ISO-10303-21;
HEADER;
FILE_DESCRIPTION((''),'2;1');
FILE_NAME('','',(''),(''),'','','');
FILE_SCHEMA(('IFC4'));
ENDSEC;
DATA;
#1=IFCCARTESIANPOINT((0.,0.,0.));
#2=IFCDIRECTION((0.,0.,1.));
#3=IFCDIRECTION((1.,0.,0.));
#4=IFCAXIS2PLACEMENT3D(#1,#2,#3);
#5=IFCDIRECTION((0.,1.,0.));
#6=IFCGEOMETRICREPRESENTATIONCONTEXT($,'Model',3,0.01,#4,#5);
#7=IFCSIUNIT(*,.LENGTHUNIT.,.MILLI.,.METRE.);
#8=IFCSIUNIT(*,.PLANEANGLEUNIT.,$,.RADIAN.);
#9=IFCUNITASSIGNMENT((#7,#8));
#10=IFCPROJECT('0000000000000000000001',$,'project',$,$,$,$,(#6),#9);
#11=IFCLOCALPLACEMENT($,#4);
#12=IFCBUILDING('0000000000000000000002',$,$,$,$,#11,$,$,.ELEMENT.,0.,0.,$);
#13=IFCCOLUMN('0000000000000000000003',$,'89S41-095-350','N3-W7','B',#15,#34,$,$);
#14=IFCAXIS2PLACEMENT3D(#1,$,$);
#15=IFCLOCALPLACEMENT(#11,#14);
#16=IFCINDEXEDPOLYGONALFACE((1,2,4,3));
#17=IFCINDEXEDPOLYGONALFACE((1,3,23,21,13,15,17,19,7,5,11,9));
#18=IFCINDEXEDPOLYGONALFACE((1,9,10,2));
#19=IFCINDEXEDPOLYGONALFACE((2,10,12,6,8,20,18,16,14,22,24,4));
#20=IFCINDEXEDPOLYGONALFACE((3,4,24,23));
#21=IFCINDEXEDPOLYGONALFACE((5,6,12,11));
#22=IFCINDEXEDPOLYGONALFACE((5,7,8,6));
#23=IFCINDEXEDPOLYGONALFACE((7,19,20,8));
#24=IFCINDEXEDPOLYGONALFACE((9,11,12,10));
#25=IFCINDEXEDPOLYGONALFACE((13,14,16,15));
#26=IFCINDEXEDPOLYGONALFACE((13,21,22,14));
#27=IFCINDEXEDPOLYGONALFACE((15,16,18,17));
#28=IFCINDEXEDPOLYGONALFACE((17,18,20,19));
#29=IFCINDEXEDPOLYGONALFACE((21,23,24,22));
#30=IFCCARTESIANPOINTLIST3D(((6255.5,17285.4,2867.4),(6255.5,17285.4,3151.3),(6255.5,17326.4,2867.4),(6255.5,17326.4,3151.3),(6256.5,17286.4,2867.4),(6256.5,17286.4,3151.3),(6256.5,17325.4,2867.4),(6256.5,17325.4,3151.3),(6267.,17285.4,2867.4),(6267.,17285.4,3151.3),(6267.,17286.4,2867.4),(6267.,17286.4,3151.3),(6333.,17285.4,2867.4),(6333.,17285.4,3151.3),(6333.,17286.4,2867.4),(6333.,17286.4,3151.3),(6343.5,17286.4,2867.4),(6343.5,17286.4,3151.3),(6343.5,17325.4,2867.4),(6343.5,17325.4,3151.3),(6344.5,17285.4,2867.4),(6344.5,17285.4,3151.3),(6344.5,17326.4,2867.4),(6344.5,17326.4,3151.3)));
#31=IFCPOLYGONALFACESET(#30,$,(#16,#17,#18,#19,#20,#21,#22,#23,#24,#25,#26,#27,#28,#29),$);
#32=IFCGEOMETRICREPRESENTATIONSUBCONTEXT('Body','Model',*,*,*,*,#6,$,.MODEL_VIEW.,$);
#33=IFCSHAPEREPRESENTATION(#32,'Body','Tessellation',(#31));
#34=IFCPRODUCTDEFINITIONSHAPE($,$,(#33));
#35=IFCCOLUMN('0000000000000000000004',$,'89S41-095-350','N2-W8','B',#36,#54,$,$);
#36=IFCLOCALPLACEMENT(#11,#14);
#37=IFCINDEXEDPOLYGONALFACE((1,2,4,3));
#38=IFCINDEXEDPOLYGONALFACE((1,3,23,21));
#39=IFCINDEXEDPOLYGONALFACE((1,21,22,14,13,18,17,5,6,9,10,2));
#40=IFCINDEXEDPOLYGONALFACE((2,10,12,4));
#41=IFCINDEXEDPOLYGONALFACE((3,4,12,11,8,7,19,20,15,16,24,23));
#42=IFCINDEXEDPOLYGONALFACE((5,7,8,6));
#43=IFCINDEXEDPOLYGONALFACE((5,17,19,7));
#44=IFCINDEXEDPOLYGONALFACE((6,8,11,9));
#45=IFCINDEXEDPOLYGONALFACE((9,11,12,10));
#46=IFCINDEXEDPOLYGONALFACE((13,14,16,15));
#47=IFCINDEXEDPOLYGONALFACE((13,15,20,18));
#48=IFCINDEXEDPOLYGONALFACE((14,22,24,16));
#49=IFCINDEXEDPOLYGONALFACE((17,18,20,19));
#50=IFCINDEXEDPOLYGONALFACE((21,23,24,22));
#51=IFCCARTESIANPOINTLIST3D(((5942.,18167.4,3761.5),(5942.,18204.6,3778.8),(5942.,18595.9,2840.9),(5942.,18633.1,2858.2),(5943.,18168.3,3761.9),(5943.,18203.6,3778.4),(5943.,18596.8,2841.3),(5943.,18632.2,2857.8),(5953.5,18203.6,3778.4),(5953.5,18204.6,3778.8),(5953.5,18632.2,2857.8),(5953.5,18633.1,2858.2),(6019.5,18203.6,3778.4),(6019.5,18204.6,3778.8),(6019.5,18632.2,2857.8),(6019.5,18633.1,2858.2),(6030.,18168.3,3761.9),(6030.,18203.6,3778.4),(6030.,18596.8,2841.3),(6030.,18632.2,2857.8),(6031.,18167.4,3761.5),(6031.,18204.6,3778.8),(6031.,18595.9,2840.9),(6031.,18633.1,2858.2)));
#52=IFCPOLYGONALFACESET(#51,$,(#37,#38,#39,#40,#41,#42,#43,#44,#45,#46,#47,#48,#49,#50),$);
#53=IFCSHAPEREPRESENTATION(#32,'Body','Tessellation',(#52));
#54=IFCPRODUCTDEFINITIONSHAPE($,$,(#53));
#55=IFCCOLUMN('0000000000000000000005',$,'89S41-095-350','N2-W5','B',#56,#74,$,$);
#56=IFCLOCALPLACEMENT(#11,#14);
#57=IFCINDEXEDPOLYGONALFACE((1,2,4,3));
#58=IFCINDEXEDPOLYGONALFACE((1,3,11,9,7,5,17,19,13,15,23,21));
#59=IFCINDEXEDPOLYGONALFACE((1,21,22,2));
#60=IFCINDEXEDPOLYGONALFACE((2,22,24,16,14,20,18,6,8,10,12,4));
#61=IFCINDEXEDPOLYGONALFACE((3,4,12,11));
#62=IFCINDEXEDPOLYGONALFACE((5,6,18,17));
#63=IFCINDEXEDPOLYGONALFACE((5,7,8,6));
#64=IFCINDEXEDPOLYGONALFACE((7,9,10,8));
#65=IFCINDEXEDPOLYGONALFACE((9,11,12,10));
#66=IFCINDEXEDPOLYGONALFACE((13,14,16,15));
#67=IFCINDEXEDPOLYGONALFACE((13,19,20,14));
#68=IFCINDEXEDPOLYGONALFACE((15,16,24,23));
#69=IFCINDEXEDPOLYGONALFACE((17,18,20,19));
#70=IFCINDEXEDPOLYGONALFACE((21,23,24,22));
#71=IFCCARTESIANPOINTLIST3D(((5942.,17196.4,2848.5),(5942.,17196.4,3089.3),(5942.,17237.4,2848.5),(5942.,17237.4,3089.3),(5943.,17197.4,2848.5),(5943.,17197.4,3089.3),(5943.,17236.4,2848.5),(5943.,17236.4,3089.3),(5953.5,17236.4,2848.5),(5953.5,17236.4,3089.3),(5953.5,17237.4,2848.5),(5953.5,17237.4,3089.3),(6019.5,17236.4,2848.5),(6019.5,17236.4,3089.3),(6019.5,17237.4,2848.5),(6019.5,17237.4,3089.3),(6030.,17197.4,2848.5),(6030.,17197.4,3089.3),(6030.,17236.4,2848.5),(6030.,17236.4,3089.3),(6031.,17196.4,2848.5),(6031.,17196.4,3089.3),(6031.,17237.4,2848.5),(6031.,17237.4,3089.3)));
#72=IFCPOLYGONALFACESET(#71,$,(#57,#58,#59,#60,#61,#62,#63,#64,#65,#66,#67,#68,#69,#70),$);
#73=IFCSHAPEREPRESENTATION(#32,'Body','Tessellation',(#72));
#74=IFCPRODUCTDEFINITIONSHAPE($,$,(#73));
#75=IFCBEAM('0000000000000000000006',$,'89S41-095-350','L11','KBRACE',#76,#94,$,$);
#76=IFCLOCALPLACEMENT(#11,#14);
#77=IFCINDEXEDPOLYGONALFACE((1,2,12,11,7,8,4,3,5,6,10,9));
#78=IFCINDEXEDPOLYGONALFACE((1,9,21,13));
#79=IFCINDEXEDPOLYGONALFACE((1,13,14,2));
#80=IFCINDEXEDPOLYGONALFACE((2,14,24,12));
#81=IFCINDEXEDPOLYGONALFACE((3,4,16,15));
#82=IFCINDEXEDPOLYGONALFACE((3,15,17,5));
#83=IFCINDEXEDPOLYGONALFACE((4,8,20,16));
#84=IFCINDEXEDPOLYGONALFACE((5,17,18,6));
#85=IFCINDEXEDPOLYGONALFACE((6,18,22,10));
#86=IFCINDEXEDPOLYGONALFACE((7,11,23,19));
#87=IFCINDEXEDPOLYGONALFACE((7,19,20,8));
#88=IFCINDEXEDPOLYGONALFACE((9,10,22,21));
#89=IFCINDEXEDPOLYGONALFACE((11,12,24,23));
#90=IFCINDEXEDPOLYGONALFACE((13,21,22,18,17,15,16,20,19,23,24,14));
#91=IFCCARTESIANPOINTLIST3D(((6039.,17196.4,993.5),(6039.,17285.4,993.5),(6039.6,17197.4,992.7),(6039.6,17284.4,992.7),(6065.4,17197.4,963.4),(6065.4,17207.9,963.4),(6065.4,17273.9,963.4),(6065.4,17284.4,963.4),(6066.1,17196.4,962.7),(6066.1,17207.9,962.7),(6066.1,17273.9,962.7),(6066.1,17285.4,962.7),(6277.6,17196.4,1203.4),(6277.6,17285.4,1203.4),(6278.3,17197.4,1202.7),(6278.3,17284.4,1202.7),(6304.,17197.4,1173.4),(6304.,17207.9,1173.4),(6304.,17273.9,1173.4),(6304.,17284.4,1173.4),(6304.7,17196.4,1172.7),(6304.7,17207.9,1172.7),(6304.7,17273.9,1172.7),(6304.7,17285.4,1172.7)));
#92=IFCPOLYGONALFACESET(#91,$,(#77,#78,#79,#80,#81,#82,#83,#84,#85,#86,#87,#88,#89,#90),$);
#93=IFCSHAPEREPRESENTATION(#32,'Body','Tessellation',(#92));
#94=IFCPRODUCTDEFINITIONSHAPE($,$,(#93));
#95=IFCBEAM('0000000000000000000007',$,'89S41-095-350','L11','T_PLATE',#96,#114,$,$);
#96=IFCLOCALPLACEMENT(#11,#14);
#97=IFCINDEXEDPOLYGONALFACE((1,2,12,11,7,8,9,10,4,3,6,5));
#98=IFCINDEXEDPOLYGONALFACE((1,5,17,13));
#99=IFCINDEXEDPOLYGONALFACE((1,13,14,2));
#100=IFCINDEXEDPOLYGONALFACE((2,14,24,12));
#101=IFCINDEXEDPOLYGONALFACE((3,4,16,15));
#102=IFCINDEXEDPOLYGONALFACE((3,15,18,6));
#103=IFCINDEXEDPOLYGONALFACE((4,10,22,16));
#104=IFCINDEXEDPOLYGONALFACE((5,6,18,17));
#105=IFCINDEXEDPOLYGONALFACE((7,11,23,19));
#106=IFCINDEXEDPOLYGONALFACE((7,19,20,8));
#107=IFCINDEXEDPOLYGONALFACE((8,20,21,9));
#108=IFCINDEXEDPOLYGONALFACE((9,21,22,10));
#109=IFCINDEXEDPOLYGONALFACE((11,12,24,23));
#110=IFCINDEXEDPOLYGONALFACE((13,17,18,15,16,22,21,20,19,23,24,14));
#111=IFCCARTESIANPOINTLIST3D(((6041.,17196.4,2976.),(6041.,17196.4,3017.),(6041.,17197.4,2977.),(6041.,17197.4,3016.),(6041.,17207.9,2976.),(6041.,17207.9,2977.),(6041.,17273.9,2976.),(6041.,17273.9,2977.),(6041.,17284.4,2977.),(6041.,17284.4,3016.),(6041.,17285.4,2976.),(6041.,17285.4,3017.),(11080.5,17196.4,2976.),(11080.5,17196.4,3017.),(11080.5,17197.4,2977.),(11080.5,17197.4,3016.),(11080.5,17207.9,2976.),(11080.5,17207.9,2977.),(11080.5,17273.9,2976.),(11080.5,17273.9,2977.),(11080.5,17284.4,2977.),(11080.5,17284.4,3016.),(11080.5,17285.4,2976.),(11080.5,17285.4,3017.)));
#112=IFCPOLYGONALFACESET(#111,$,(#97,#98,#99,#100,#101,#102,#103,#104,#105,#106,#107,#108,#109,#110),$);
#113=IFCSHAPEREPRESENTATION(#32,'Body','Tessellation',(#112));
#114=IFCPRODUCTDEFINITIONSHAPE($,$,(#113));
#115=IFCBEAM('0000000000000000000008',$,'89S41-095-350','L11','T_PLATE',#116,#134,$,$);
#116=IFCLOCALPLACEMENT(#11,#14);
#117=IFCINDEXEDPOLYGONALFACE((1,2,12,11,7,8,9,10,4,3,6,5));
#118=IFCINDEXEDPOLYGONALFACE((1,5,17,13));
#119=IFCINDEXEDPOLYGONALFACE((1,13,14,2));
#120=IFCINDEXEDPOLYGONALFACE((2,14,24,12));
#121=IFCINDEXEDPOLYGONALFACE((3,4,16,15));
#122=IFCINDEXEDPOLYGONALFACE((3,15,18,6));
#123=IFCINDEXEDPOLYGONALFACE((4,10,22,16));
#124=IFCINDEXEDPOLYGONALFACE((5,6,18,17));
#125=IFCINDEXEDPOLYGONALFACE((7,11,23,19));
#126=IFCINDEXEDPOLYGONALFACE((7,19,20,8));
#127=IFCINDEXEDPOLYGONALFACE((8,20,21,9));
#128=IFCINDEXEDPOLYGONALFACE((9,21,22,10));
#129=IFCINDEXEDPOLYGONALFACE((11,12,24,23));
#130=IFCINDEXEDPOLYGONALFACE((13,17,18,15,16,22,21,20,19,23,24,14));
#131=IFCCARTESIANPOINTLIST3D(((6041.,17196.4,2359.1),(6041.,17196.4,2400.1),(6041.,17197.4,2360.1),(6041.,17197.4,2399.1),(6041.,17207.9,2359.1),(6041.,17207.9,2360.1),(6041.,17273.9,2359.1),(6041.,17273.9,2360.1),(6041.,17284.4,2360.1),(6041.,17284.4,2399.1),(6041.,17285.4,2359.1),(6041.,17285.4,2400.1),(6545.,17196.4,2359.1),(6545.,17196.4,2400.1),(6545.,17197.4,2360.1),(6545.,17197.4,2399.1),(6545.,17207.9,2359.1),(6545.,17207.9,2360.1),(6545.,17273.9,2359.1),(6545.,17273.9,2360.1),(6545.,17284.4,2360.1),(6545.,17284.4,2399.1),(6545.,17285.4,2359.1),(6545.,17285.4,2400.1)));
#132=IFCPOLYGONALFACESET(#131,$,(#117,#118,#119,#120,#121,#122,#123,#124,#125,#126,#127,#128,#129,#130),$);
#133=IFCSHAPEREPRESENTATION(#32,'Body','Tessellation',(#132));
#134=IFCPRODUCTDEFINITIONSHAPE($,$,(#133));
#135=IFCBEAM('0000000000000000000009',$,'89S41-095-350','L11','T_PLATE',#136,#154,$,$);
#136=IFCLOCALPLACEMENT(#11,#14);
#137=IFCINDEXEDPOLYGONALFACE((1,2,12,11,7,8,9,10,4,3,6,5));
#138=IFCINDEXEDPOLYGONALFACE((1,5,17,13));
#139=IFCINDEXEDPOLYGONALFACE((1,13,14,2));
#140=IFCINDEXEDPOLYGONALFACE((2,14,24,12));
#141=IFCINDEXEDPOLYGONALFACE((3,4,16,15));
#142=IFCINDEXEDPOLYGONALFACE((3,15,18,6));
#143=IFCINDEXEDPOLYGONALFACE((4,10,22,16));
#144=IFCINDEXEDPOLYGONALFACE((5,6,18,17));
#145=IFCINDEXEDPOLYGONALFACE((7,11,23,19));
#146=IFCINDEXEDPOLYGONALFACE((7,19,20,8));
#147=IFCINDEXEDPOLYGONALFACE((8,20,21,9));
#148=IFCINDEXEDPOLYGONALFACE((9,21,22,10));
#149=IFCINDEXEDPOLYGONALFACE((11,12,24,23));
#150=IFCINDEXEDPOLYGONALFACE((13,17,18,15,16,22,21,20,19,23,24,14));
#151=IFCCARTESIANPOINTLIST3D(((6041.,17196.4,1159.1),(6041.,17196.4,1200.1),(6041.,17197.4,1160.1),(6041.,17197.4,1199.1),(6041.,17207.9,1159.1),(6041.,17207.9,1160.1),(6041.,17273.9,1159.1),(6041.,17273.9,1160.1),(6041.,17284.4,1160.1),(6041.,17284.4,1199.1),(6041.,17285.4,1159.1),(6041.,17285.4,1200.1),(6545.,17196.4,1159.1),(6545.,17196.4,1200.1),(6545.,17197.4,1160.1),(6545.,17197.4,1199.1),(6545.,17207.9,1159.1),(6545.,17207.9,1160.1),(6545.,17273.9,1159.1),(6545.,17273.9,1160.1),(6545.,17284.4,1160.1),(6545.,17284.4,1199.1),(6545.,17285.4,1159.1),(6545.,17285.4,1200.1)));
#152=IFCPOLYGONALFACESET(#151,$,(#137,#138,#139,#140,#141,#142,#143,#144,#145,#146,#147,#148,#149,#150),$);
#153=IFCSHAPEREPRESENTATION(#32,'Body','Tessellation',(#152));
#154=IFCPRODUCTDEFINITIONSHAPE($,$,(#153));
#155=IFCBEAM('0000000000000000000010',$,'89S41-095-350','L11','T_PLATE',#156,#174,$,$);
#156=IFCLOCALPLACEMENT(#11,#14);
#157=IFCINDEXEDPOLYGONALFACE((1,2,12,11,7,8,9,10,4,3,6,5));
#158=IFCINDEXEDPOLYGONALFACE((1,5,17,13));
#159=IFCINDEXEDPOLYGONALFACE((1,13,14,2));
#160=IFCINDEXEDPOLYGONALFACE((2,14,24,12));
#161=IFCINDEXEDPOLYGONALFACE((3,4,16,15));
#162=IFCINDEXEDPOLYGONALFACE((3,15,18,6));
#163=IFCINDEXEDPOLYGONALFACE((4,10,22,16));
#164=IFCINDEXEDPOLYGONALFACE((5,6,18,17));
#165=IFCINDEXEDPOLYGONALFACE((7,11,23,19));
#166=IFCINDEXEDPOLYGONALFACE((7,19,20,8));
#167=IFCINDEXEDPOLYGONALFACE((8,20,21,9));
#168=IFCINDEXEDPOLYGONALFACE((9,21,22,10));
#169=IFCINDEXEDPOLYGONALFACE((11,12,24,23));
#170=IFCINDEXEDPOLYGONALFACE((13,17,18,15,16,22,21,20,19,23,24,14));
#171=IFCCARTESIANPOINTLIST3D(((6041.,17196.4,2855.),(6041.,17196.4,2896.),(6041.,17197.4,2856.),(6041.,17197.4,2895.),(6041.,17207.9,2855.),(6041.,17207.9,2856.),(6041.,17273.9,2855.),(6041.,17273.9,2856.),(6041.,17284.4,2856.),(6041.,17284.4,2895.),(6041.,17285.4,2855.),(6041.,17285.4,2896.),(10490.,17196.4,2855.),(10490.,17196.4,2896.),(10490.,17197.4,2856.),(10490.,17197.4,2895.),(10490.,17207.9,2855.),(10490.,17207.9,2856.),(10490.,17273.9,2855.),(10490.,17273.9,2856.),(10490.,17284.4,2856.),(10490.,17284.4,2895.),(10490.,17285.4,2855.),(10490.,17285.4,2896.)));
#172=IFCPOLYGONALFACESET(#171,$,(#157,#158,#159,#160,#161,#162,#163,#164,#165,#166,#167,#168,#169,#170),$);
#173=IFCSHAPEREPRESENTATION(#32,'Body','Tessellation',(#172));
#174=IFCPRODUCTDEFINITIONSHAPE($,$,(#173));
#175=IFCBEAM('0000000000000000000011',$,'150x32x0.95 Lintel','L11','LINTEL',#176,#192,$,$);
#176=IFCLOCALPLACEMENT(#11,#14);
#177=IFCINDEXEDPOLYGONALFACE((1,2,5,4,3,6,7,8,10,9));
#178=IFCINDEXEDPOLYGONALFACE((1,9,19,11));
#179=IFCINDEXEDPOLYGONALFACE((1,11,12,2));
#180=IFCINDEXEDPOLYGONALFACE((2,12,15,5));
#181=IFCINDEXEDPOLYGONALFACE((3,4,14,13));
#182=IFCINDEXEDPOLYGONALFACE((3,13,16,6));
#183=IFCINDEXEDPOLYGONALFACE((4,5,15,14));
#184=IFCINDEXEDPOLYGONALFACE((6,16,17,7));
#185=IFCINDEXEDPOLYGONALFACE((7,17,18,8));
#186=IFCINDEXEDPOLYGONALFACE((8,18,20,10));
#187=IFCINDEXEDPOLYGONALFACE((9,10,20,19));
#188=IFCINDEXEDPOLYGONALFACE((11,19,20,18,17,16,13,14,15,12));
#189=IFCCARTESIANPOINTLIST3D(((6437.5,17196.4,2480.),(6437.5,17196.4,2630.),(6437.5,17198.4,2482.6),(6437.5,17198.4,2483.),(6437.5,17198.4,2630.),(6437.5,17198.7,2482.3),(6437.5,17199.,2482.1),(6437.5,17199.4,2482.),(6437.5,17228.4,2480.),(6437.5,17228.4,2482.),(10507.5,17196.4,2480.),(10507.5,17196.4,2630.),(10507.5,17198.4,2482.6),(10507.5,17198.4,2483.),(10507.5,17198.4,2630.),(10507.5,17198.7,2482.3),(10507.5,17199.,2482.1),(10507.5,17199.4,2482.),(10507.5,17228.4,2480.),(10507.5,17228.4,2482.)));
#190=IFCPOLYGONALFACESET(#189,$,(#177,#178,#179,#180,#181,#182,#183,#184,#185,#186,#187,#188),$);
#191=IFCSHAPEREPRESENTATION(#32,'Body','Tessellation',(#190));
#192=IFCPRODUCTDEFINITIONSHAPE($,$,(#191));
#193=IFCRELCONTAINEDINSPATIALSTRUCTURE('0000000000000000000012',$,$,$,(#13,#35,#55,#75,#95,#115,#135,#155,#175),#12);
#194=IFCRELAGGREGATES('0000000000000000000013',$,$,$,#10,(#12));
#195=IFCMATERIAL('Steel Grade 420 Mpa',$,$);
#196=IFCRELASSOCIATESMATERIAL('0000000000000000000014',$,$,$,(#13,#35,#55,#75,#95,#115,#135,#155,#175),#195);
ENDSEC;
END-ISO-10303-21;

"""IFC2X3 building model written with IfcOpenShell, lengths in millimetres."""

from ifc_helpers import new_model, si_unit, direction, frame, origin, origin_with_axes, origin_2d_with_axis, place, context, subcontext, project, spatial, l_section, c_section, extrude, source, transform, mapped, material, element, save


model = new_model("IFC2X3")

# Units and contexts
model_context = context("Model", 3, precision=0.01, world=origin_with_axes(), true_north=direction((0.0, 1.0, 0.0)))
body_context = subcontext(model_context, "Body", "Model", "MODEL_VIEW")
ifc_project = project(units=[si_unit("LENGTHUNIT", "METRE", prefix="MILLI"), si_unit("PLANEANGLEUNIT", "RADIAN")], contexts=[model_context])

# Building
building_placement = place(None, origin_with_axes())
building = spatial("IfcBuilding", under=ifc_project, at=building_placement, CompositionType="ELEMENT", ElevationOfRefHeight=0.0, ElevationOfTerrain=0.0)

# Columns
ifc_material = material(Name="Steel Grade 420 Mpa")
shared_shape_1 = source(origin(), body_context, "Body", "SweptSolid", [
    extrude(c_section(Depth=89.0, Width=41.0, WallThickness=1.0, Girth=11.5, at=origin_2d_with_axis()), origin_with_axes(), (0.0, 0.0, 1.0), 283.9),
])
column_1_placement = place(None, frame((6300.0, 17305.9, 3151.3), z_axis=(0.0, 0.0, -1.0), x_axis=(0.0, -1.0, 0.0)))
element("IfcColumn", 1, at=column_1_placement, inside=building, material=ifc_material, Name="89S41-095-350", Description="N3-W7", ObjectType="B", context=body_context, shape_type="MappedRepresentation", body=[
    mapped(shared_shape_1, transform((0.0, 0.0, 0.0), scale=1.0)),
])
shared_shape_2 = source(origin(), body_context, "Body", "SweptSolid", [
    extrude(c_section(Depth=89.0, Width=41.0, WallThickness=1.0, Girth=11.5, at=origin_2d_with_axis()), origin_with_axes(), (0.0, 0.0, 1.0), 1015.5),
])
column_2_placement = place(None, frame((5986.5, 18614.5, 2849.5), z_axis=(0.0, -0.422026, 0.906584), x_axis=(0.0, 0.906584, 0.422026)))
element("IfcColumn", 2, at=column_2_placement, inside=building, material=ifc_material, Name="89S41-095-350", Description="N2-W8", ObjectType="B", context=body_context, shape_type="MappedRepresentation", body=[
    mapped(shared_shape_2, transform((0.0, 0.0, 0.0), scale=1.0)),
])
shared_shape_3 = source(origin(), body_context, "Body", "SweptSolid", [
    extrude(c_section(Depth=89.0, Width=41.0, WallThickness=1.0, Girth=11.5, at=origin_2d_with_axis()), origin_with_axes(), (0.0, 0.0, 1.0), 240.8),
])
column_3_placement = place(None, frame((5986.5, 17216.9, 2848.5), z_axis=(0.0, 0.0, 1.0), x_axis=(0.0, 1.0, 0.0)))
element("IfcColumn", 3, at=column_3_placement, inside=building, material=ifc_material, Name="89S41-095-350", Description="N2-W5", ObjectType="B", context=body_context, shape_type="MappedRepresentation", body=[
    mapped(shared_shape_3, transform((0.0, 0.0, 0.0), scale=1.0)),
])

# Beams
shared_shape_4 = source(origin(), body_context, "Body", "SweptSolid", [
    extrude(c_section(Depth=89.0, Width=41.0, WallThickness=1.0, Girth=11.5, at=origin_2d_with_axis()), origin_with_axes(), (0.0, 0.0, 1.0), 317.9),
])
beam_1_placement = place(None, frame((6052.5, 17240.9, 978.1), z_axis=(0.750781, 0.0, 0.660551), x_axis=(0.660551, 0.0, -0.750781)))
element("IfcBeam", 4, at=beam_1_placement, inside=building, material=ifc_material, Name="89S41-095-350", Description="L11", ObjectType="KBRACE", context=body_context, shape_type="MappedRepresentation", body=[
    mapped(shared_shape_4, transform((0.0, 0.0, 0.0), scale=1.0)),
])
shared_shape_5 = source(origin(), body_context, "Body", "SweptSolid", [
    extrude(c_section(Depth=89.0, Width=41.0, WallThickness=1.0, Girth=11.5, at=origin_2d_with_axis()), origin_with_axes(), (0.0, 0.0, 1.0), 5039.5),
])
beam_2_placement = place(None, frame((6041.0, 17240.9, 2996.5), z_axis=(1.0, 0.0, 0.0), x_axis=(0.0, 0.0, -1.0)))
element("IfcBeam", 5, at=beam_2_placement, inside=building, material=ifc_material, Name="89S41-095-350", Description="L11", ObjectType="T_PLATE", context=body_context, shape_type="MappedRepresentation", body=[
    mapped(shared_shape_5, transform((0.0, 0.0, 0.0), scale=1.0)),
])
shared_shape_6 = source(origin(), body_context, "Body", "SweptSolid", [
    extrude(c_section(Depth=89.0, Width=41.0, WallThickness=1.0, Girth=11.5, at=origin_2d_with_axis()), origin_with_axes(), (0.0, 0.0, 1.0), 504.0),
])
beam_3_placement = place(None, frame((6041.0, 17240.9, 2379.6), z_axis=(1.0, 0.0, 0.0), x_axis=(0.0, 0.0, -1.0)))
element("IfcBeam", 6, at=beam_3_placement, inside=building, material=ifc_material, Name="89S41-095-350", Description="L11", ObjectType="T_PLATE", context=body_context, shape_type="MappedRepresentation", body=[
    mapped(shared_shape_6, transform((0.0, 0.0, 0.0), scale=1.0)),
])
shared_shape_7 = source(origin(), body_context, "Body", "SweptSolid", [
    extrude(c_section(Depth=89.0, Width=41.0, WallThickness=1.0, Girth=11.5, at=origin_2d_with_axis()), origin_with_axes(), (0.0, 0.0, 1.0), 504.0),
])
beam_4_placement = place(None, frame((6041.0, 17240.9, 1179.6), z_axis=(1.0, 0.0, 0.0), x_axis=(0.0, 0.0, -1.0)))
element("IfcBeam", 7, at=beam_4_placement, inside=building, material=ifc_material, Name="89S41-095-350", Description="L11", ObjectType="T_PLATE", context=body_context, shape_type="MappedRepresentation", body=[
    mapped(shared_shape_7, transform((0.0, 0.0, 0.0), scale=1.0)),
])
shared_shape_8 = source(origin(), body_context, "Body", "SweptSolid", [
    extrude(c_section(Depth=89.0, Width=41.0, WallThickness=1.0, Girth=11.5, at=origin_2d_with_axis()), origin_with_axes(), (0.0, 0.0, 1.0), 4449.0),
])
beam_5_placement = place(None, frame((6041.0, 17240.9, 2875.5), z_axis=(1.0, 0.0, 0.0), x_axis=(0.0, 0.0, -1.0)))
element("IfcBeam", 8, at=beam_5_placement, inside=building, material=ifc_material, Name="89S41-095-350", Description="L11", ObjectType="T_PLATE", context=body_context, shape_type="MappedRepresentation", body=[
    mapped(shared_shape_8, transform((0.0, 0.0, 0.0), scale=1.0)),
])
shared_shape_9 = source(origin(), body_context, "Body", "SweptSolid", [
    extrude(l_section(Depth=150.0, Width=32.0, Thickness=2.0, FilletRadius=1.0, EdgeRadius=0.0, at=origin_2d_with_axis()), origin_with_axes(), (0.0, 0.0, 1.0), 4070.0),
])
beam_6_placement = place(None, frame((6437.5, 17212.4, 2555.0), z_axis=(1.0, 0.0, 0.0), x_axis=(0.0, 1.0, 0.0)))
element("IfcBeam", 9, at=beam_6_placement, inside=building, material=ifc_material, Name="150x32x0.95 Lintel", Description="L11", ObjectType="LINTEL", context=body_context, shape_type="MappedRepresentation", body=[
    mapped(shared_shape_9, transform((0.0, 0.0, 0.0), scale=1.0)),
])

save(model, "model.ifc")
